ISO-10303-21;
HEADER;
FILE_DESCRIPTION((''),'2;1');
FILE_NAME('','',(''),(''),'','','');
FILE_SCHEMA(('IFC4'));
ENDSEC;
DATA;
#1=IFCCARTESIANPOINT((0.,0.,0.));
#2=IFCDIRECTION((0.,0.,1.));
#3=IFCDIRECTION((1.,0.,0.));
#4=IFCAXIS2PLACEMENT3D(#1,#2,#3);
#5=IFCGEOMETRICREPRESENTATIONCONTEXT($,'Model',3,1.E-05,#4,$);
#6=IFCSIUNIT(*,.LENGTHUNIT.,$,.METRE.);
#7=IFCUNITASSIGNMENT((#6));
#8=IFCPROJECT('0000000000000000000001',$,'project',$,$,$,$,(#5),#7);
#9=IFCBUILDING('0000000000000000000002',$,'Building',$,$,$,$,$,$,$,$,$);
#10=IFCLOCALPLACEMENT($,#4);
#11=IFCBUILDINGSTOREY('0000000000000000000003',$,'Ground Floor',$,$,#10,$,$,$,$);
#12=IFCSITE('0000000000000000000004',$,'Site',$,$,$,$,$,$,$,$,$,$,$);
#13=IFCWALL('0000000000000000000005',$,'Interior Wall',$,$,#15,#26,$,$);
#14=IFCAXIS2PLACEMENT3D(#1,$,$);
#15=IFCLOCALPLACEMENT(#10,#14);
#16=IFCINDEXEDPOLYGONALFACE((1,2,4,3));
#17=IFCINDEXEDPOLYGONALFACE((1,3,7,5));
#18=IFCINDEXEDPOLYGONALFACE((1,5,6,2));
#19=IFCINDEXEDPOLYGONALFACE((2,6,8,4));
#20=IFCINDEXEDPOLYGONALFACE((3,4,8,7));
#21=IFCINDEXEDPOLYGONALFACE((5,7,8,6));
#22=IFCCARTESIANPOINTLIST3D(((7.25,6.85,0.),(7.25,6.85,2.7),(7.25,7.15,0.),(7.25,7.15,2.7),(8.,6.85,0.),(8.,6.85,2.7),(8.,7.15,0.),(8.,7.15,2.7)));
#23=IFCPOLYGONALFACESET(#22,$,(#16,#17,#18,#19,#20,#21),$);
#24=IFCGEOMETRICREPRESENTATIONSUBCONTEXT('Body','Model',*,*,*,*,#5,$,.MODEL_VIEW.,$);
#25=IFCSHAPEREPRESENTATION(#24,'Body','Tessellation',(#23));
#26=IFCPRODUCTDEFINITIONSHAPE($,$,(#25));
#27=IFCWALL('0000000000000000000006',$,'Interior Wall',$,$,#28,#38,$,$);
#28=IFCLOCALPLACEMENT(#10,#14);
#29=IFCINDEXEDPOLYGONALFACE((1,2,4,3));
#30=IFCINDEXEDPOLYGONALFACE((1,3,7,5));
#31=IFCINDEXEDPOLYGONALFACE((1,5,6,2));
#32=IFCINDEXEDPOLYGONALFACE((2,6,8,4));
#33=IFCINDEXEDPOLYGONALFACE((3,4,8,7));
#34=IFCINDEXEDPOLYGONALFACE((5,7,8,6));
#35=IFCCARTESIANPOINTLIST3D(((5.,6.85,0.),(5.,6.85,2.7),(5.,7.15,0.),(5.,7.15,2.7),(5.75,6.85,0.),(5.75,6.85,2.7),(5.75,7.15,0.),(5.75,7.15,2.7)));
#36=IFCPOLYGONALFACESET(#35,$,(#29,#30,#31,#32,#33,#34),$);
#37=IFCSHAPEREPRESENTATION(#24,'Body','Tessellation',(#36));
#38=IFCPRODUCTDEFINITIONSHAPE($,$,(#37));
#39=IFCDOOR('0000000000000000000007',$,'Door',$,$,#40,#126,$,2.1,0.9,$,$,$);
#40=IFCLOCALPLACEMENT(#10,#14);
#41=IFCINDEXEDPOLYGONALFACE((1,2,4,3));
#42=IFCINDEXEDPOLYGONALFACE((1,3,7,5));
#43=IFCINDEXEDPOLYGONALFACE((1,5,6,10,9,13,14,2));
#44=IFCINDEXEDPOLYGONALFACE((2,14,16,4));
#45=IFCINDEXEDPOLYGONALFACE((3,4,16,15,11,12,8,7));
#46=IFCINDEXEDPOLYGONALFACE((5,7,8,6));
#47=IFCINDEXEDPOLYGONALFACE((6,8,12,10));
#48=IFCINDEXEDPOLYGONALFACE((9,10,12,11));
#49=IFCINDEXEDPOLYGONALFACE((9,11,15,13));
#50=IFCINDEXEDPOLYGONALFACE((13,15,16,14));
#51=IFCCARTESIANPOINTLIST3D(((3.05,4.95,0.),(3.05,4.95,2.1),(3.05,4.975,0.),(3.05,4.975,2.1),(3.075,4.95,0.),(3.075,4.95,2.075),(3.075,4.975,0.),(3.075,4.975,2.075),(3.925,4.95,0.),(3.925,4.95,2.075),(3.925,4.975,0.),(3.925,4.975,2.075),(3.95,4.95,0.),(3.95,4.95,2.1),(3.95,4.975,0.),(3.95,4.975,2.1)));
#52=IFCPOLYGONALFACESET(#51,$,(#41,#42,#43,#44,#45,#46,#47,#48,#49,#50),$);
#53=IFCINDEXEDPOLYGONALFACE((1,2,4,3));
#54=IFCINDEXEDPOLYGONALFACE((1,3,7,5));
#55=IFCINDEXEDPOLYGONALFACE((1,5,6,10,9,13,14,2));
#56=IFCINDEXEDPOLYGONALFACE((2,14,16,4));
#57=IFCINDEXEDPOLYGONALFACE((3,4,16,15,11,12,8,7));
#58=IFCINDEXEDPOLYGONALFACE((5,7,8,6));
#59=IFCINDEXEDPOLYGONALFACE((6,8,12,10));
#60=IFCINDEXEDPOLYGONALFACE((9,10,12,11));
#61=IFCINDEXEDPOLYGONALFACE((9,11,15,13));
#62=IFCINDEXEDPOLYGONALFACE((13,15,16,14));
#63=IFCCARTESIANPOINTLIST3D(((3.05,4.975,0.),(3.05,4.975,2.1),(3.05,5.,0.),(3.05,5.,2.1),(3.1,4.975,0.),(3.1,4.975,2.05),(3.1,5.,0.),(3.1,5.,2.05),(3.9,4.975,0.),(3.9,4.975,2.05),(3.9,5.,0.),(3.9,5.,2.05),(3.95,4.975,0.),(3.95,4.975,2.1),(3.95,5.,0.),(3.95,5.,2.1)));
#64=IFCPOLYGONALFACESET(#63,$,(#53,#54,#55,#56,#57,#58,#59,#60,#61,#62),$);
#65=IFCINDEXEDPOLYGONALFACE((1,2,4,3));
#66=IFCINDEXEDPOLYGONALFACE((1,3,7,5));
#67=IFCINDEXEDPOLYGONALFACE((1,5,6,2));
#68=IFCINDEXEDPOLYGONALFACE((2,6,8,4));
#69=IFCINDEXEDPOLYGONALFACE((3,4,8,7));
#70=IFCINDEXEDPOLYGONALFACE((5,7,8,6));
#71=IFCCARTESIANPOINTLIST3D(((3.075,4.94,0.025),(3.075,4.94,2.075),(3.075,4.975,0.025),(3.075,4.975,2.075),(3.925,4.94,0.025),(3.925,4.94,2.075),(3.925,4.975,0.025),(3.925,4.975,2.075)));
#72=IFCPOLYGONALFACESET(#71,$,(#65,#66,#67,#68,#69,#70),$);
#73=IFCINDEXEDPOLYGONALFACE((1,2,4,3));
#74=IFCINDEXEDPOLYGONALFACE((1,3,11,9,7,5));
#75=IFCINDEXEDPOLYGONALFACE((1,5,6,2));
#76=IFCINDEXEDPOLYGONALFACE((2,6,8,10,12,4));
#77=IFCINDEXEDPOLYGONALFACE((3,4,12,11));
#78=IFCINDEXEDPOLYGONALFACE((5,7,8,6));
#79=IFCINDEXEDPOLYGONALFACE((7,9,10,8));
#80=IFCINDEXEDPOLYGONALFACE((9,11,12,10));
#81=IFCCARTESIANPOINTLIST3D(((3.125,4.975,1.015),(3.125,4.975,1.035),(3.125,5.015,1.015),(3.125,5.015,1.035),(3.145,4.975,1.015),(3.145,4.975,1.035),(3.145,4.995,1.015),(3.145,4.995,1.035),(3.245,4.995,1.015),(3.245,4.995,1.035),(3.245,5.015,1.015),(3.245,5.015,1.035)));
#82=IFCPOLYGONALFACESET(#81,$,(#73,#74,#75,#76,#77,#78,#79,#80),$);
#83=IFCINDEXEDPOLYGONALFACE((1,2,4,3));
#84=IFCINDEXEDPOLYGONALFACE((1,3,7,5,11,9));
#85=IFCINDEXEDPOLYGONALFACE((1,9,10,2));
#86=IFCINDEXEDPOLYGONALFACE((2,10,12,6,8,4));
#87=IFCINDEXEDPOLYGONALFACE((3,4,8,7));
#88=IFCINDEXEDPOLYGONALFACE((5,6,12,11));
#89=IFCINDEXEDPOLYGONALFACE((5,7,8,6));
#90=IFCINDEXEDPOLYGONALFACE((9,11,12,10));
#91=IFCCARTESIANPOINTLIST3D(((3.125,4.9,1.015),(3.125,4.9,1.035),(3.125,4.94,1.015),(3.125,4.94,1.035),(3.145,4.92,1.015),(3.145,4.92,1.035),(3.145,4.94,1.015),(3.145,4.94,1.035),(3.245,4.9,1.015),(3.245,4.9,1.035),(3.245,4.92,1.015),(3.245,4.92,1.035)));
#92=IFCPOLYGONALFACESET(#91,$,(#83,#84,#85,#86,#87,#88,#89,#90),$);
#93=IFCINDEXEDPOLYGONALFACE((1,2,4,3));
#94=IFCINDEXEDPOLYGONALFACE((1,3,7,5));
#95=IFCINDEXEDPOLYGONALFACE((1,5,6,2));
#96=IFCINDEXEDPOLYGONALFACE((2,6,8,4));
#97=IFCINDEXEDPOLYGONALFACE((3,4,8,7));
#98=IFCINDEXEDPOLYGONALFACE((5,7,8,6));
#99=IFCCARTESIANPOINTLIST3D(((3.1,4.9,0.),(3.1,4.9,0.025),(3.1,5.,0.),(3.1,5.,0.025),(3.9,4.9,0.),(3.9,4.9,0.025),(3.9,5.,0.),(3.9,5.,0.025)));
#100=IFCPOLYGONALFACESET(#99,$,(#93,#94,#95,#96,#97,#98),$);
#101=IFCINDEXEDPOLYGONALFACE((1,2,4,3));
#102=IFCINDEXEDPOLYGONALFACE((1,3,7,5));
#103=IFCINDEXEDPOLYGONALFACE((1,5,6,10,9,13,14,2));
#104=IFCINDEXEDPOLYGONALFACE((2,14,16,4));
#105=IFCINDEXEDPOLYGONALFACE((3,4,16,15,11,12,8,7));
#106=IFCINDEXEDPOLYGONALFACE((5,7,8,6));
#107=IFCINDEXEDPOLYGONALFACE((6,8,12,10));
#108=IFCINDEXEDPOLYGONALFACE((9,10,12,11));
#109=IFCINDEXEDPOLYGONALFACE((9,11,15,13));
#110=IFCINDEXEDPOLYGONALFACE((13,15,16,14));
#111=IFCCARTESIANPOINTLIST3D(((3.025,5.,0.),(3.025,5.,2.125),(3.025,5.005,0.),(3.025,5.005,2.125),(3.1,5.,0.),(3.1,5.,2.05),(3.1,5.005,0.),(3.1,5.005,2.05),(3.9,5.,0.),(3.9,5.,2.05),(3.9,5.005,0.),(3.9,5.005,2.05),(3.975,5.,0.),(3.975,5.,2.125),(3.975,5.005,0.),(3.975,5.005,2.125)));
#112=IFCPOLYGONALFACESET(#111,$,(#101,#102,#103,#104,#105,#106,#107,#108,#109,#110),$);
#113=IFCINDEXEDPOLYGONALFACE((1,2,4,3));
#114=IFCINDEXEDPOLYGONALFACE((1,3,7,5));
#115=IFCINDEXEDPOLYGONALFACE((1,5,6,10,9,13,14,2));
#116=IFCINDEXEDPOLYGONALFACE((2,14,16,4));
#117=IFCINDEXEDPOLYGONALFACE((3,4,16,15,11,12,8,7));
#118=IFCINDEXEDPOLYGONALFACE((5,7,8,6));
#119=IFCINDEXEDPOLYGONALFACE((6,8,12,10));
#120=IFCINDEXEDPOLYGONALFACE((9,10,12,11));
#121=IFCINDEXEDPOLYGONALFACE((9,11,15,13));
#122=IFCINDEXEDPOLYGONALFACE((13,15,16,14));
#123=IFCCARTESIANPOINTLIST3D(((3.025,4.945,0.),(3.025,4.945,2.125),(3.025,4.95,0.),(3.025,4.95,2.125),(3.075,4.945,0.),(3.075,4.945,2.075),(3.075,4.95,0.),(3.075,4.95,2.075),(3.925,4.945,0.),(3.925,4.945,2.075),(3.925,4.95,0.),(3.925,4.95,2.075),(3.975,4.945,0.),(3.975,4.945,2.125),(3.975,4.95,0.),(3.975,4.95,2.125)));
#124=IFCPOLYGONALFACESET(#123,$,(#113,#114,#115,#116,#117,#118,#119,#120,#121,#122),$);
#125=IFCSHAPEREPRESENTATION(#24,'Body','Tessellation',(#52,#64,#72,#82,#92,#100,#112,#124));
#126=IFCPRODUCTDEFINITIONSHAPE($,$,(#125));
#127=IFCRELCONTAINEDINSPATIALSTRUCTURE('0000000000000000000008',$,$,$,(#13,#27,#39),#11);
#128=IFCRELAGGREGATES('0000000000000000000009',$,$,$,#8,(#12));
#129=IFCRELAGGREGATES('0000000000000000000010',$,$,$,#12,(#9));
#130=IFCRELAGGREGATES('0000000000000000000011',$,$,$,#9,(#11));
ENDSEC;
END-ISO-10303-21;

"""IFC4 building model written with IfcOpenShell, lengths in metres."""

from ifc_helpers import new_model, si_unit, frame, origin_with_axes, place, context, subcontext, project, spatial, line, indexed_curve, outline, extrude, element, save


model = new_model("IFC4")

# Units and contexts
model_context = context("Model", 3, precision=1e-05, world=origin_with_axes())
body_context = subcontext(model_context, "Body", "Model", "MODEL_VIEW")
ifc_project = project(units=[si_unit("LENGTHUNIT", "METRE")], contexts=[model_context])

# Site, building, storey
site = spatial("IfcSite", under=ifc_project, Name="Site")
building = spatial("IfcBuilding", under=site, Name="Building")
storey_placement = place(None, origin_with_axes())
storey = spatial("IfcBuildingStorey", under=building, at=storey_placement, Name="Ground Floor")

# Walls
for number, where, z_axis, x_axis, name in (
    (1, (8.0, 7.0, 0.0), (0.0, 0.0, 1.0), (-1.0, 0.0, 0.0), "Interior Wall"),
    (2, (5.75, 7.0, 0.0), (0.0, 0.0, 1.0), (-1.0, 0.0, 0.0), "Interior Wall"),
):
    element("IfcWall", number, at=place(storey_placement, frame(where, z_axis=z_axis, x_axis=x_axis)), inside=storey, Name=name, context=body_context, shape_type="SweptSolid", body=[
        extrude(outline(indexed_curve([(0.0, 0.0), (0.0, 0.3), (0.75, 0.3), (0.75, 0.0), (0.0, 0.0)], self_intersect=False)), frame((0.0, -0.15, 0.0), z_axis=(0.0, 0.0, 1.0), x_axis=(1.0, 0.0, 0.0)), (0.0, 0.0, 1.0), 2.7),
    ])

# Door
door_1_placement = place(storey_placement, frame((3.95, 5.0, 0.0), z_axis=(0.0, 0.0, 1.0), x_axis=(-1.0, 0.0, 0.0)))
element("IfcDoor", 3, at=door_1_placement, inside=storey, Name="Door", OverallHeight=2.1, OverallWidth=0.9, context=body_context, shape_type="SweptSolid", body=[
    extrude(outline(indexed_curve([(0.0, 0.0), (0.0, 2.1), (0.9, 2.1), (0.9, 0.0), (0.875, 0.0), (0.875, 2.075), (0.025, 2.075), (0.025, 0.0)], segments=[line(1, 2, 3, 4, 5, 6, 7, 8, 1)])), frame((0.0, 0.025, 0.0), z_axis=(0.0, -1.0, 0.0), x_axis=(1.0, 0.0, 0.0)), (0.0, 0.0, -1.0), 0.025),
    extrude(outline(indexed_curve([(0.0, 0.0), (0.0, 2.1), (0.9, 2.1), (0.9, 0.0), (0.85, 0.0), (0.85, 2.05), (0.05, 2.05), (0.05, 0.0)], segments=[line(1, 2, 3, 4, 5, 6, 7, 8, 1)])), frame((0.0, 0.0, 0.0), z_axis=(0.0, -1.0, 0.0), x_axis=(1.0, 0.0, 0.0)), (0.0, 0.0, -1.0), 0.025),
    extrude(outline(indexed_curve([(0.0, 0.0), (0.85, 0.0), (0.85, 0.035), (0.0, 0.035)], segments=[line(1, 2, 3, 4, 1)])), frame((0.025, 0.025, 0.025), z_axis=(0.0, 0.0, 1.0), x_axis=(1.0, 0.0, 0.0)), (0.0, 0.0, 1.0), 2.05),
    extrude(outline(indexed_curve([(0.0, 0.0), (0.0, -0.04), (-0.12, -0.04), (-0.12, -0.02), (-0.02, -0.02), (-0.02, 0.0)], segments=[line(1, 2, 3, 4, 5, 6, 1)])), frame((0.825, 0.025, 1.015), z_axis=(0.0, 0.0, 1.0), x_axis=(1.0, 0.0, 0.0)), (0.0, 0.0, 1.0), 0.02),
    extrude(outline(indexed_curve([(0.0, 0.0), (0.0, 0.04), (-0.12, 0.04), (-0.12, 0.02), (-0.02, 0.02), (-0.02, 0.0)], segments=[line(1, 2, 3, 4, 5, 6, 1)])), frame((0.825, 0.06, 1.015), z_axis=(0.0, 0.0, 1.0), x_axis=(1.0, 0.0, 0.0)), (0.0, 0.0, 1.0), 0.02),
    extrude(outline(indexed_curve([(0.0, 0.0), (0.8, 0.0), (0.8, 0.1), (0.0, 0.1)], segments=[line(1, 2, 3, 4, 1)])), frame((0.05, 0.0, 0.0), z_axis=(0.0, 0.0, 1.0), x_axis=(1.0, 0.0, 0.0)), (0.0, 0.0, 1.0), 0.025),
    extrude(outline(indexed_curve([(0.0, 0.0), (0.0, 2.125), (0.95, 2.125), (0.95, 0.0), (0.875, 0.0), (0.875, 2.05), (0.075, 2.05), (0.075, 0.0)], segments=[line(1, 2, 3, 4, 5, 6, 7, 8, 1)])), frame((-0.025, -0.005, 0.0), z_axis=(0.0, -1.0, 0.0), x_axis=(1.0, 0.0, 0.0)), (0.0, 0.0, -1.0), 0.005),
    extrude(outline(indexed_curve([(0.0, 0.0), (0.0, 2.125), (0.95, 2.125), (0.95, 0.0), (0.9, 0.0), (0.9, 2.075), (0.05, 2.075), (0.05, 0.0)], segments=[line(1, 2, 3, 4, 5, 6, 7, 8, 1)])), frame((-0.025, 0.05, 0.0), z_axis=(0.0, -1.0, 0.0), x_axis=(1.0, 0.0, 0.0)), (0.0, 0.0, -1.0), 0.005),
])

save(model, "model.ifc")
